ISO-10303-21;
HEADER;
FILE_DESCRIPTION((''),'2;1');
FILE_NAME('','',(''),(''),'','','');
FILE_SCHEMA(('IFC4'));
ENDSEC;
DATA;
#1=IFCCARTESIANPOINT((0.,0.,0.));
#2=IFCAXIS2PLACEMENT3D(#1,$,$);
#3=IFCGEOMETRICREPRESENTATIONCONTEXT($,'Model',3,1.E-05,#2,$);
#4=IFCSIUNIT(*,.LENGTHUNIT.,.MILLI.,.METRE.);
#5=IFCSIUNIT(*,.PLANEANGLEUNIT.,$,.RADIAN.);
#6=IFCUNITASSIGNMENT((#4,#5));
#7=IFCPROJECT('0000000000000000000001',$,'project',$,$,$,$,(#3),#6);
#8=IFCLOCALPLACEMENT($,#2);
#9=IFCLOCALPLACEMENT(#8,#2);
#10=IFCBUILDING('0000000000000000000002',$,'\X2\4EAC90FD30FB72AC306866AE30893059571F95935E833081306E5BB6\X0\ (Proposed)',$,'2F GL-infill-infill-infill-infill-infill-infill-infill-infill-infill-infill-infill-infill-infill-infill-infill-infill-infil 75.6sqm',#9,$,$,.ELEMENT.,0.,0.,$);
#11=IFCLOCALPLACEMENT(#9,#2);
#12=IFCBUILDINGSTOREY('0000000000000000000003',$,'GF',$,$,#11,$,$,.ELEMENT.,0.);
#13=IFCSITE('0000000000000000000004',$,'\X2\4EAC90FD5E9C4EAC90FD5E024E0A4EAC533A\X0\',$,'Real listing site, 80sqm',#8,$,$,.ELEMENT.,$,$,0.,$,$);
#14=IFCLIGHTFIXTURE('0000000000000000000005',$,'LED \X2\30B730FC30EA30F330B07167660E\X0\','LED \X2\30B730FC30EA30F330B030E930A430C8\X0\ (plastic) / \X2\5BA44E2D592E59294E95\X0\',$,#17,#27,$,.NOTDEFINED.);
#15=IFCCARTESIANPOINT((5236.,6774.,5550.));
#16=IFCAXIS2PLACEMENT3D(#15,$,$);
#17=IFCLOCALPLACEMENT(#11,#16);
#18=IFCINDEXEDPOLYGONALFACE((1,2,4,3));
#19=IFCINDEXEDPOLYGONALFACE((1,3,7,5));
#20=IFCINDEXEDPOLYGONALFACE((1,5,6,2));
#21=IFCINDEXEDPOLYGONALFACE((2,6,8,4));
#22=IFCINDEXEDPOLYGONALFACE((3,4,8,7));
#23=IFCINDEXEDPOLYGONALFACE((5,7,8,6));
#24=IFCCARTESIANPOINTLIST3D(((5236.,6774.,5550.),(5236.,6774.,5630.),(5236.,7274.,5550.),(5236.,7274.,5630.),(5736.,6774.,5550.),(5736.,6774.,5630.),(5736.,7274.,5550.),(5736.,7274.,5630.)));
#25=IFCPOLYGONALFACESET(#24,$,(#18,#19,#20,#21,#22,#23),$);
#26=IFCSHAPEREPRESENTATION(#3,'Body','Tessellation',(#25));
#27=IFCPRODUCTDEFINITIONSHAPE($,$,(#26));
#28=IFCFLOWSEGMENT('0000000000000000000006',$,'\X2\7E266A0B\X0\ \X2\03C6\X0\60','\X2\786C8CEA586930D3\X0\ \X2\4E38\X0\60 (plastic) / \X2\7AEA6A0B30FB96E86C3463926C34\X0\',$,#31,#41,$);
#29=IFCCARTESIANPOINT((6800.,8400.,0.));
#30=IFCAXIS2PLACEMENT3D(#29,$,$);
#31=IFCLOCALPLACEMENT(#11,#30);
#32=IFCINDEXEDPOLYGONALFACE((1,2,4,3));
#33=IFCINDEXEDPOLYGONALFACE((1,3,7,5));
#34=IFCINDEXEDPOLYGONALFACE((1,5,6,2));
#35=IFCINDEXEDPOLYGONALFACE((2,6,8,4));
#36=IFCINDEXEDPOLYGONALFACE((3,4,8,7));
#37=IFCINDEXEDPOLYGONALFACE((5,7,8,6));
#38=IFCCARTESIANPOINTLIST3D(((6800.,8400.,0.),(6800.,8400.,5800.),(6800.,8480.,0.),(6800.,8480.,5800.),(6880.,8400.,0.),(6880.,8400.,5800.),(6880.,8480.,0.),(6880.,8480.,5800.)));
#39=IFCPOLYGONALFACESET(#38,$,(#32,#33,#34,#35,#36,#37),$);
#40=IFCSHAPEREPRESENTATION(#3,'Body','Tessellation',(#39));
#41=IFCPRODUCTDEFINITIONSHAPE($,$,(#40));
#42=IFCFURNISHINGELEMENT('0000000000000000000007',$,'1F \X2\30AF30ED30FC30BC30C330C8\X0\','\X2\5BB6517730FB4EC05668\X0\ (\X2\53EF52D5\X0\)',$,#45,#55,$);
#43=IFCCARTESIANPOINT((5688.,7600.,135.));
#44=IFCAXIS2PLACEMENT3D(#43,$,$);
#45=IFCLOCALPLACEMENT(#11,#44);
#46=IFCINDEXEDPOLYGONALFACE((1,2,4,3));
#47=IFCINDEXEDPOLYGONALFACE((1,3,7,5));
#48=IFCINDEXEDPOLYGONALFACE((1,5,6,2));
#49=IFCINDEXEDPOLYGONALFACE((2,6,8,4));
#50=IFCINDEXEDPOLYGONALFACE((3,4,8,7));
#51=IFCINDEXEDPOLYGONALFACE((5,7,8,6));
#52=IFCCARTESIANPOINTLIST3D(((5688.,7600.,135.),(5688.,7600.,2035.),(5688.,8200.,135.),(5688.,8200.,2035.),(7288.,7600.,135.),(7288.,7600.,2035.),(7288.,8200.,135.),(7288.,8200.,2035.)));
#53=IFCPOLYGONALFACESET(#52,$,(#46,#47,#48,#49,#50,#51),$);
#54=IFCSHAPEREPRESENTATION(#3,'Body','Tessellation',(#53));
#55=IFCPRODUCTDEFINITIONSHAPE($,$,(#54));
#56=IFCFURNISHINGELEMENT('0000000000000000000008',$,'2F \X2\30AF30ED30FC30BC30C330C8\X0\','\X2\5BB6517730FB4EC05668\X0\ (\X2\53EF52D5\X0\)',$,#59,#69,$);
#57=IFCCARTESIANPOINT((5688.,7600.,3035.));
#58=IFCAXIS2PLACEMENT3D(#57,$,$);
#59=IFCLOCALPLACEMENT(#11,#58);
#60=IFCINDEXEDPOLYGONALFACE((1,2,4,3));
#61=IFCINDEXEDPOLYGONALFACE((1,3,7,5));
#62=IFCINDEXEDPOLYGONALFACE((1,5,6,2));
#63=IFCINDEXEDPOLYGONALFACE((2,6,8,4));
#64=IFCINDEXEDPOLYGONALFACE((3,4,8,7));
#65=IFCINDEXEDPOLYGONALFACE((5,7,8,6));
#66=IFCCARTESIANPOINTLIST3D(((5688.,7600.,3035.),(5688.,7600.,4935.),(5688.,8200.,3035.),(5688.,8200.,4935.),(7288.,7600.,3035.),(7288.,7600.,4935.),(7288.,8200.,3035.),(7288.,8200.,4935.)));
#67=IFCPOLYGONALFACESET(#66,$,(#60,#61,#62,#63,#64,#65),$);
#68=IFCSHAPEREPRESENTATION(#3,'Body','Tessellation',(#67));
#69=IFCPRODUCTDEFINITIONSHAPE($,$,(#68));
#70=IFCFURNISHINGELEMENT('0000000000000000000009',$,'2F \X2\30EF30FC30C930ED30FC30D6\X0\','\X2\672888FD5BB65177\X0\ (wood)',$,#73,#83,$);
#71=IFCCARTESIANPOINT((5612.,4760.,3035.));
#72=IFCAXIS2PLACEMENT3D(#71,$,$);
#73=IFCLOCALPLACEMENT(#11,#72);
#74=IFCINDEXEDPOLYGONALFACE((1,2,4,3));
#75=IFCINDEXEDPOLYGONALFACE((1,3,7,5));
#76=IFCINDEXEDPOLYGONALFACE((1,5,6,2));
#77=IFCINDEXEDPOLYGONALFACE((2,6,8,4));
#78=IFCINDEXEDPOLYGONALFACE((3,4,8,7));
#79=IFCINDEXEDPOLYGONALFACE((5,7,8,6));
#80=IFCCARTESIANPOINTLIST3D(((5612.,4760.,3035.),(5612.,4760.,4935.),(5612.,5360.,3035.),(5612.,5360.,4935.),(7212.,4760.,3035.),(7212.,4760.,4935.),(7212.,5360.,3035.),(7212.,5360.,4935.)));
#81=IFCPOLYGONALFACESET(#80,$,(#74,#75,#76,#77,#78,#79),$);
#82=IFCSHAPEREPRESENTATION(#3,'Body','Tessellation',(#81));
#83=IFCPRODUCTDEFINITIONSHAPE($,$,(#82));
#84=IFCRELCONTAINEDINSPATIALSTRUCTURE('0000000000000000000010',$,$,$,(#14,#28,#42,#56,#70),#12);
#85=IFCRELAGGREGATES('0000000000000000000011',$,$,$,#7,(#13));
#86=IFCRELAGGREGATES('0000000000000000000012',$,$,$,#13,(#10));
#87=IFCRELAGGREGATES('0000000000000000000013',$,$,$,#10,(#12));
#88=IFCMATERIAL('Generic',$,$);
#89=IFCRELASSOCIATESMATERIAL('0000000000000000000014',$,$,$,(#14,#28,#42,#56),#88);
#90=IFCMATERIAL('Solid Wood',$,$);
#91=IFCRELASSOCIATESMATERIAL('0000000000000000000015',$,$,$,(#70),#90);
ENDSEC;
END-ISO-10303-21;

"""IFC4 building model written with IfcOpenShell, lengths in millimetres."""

from ifc_helpers import new_model, si_unit, frame, frame_2d, origin, place, context, project, spatial, rectangle, extrude, material, element, save


model = new_model("IFC4")

# Units and contexts
model_context = context("Model", 3, precision=1e-05, world=origin())
ifc_project = project(units=[si_unit("LENGTHUNIT", "METRE", prefix="MILLI"), si_unit("PLANEANGLEUNIT", "RADIAN")], contexts=[model_context])

# Site, building, storey
site_placement = place(None, origin())
site = spatial("IfcSite", under=ifc_project, at=site_placement, Name="京都府京都市上京区", ObjectType="Real listing site, 80sqm", CompositionType="ELEMENT", RefElevation=0.0)
building_placement = place(site_placement, origin())
building = spatial("IfcBuilding", under=site, at=building_placement, Name="京都・犬と暮らす土間広めの家 (Proposed)", ObjectType="2F GL-infill-infill-infill-infill-infill-infill-infill-infill-infill-infill-infill-infill-infill-infill-infill-infill-infil 75.6sqm", CompositionType="ELEMENT", ElevationOfRefHeight=0.0, ElevationOfTerrain=0.0)
storey_placement = place(building_placement, origin())
storey = spatial("IfcBuildingStorey", under=building, at=storey_placement, Name="GF", CompositionType="ELEMENT", Elevation=0.0)

# Shared definitions
ifc_material_1 = material(Name="Solid Wood")

# Shared definitions
ifc_material_2 = material(Name="Generic")

# Light fixture
light_fixture_1_placement = place(storey_placement, frame((5236.0, 6774.0, 5550.0)))
element("IfcLightFixture", 1, at=light_fixture_1_placement, inside=storey, material=ifc_material_2, Name="LED シーリング照明", Description="LED シーリングライト (plastic) / 室中央天井", PredefinedType="NOTDEFINED", context=model_context, shape_type="SweptSolid", body=[
    extrude(rectangle(XDim=500.0, YDim=500.0, at=frame_2d((250.0, 250.0))), frame((5236.0, 6774.0, 5550.0)), (0.0, 0.0, 1.0), 80.0),
])

# Flow segment
flow_segment_placement = place(storey_placement, frame((6800.0, 8400.0, 0.0)))
element("IfcFlowSegment", 2, at=flow_segment_placement, inside=storey, material=ifc_material_2, Name="縦樋 φ60", Description="硬質塩ビ 丸60 (plastic) / 竪樋・雨水排水", context=model_context, shape_type="SweptSolid", body=[
    extrude(rectangle(XDim=80.0, YDim=80.0, at=frame_2d((40.0, 40.0))), frame((6800.0, 8400.0, 0.0)), (0.0, 0.0, 1.0), 5800.0),
])

# Furnishing elements
furnishing_1_placement = place(storey_placement, frame((5688.0, 7600.0, 135.0)))
element("IfcFurnishingElement", 3, at=furnishing_1_placement, inside=storey, material=ifc_material_2, Name="1F クローゼット", Description="家具・什器 (可動)", context=model_context, shape_type="SweptSolid", body=[
    extrude(rectangle(XDim=1600.0, YDim=600.0, at=frame_2d((800.0, 300.0))), frame((5688.0, 7600.0, 135.0)), (0.0, 0.0, 1.0), 1900.0),
])
furnishing_2_placement = place(storey_placement, frame((5688.0, 7600.0, 3035.0)))
element("IfcFurnishingElement", 4, at=furnishing_2_placement, inside=storey, material=ifc_material_2, Name="2F クローゼット", Description="家具・什器 (可動)", context=model_context, shape_type="SweptSolid", body=[
    extrude(rectangle(XDim=1600.0, YDim=600.0, at=frame_2d((800.0, 300.0))), frame((5688.0, 7600.0, 3035.0)), (0.0, 0.0, 1.0), 1900.0),
])
furnishing_3_placement = place(storey_placement, frame((5612.0, 4760.0, 3035.0)))
element("IfcFurnishingElement", 5, at=furnishing_3_placement, inside=storey, material=ifc_material_1, Name="2F ワードローブ", Description="木製家具 (wood)", context=model_context, shape_type="SweptSolid", body=[
    extrude(rectangle(XDim=1600.0, YDim=600.0, at=frame_2d((800.0, 300.0))), frame((5612.0, 4760.0, 3035.0)), (0.0, 0.0, 1.0), 1900.0),
])

save(model, "model.ifc")
